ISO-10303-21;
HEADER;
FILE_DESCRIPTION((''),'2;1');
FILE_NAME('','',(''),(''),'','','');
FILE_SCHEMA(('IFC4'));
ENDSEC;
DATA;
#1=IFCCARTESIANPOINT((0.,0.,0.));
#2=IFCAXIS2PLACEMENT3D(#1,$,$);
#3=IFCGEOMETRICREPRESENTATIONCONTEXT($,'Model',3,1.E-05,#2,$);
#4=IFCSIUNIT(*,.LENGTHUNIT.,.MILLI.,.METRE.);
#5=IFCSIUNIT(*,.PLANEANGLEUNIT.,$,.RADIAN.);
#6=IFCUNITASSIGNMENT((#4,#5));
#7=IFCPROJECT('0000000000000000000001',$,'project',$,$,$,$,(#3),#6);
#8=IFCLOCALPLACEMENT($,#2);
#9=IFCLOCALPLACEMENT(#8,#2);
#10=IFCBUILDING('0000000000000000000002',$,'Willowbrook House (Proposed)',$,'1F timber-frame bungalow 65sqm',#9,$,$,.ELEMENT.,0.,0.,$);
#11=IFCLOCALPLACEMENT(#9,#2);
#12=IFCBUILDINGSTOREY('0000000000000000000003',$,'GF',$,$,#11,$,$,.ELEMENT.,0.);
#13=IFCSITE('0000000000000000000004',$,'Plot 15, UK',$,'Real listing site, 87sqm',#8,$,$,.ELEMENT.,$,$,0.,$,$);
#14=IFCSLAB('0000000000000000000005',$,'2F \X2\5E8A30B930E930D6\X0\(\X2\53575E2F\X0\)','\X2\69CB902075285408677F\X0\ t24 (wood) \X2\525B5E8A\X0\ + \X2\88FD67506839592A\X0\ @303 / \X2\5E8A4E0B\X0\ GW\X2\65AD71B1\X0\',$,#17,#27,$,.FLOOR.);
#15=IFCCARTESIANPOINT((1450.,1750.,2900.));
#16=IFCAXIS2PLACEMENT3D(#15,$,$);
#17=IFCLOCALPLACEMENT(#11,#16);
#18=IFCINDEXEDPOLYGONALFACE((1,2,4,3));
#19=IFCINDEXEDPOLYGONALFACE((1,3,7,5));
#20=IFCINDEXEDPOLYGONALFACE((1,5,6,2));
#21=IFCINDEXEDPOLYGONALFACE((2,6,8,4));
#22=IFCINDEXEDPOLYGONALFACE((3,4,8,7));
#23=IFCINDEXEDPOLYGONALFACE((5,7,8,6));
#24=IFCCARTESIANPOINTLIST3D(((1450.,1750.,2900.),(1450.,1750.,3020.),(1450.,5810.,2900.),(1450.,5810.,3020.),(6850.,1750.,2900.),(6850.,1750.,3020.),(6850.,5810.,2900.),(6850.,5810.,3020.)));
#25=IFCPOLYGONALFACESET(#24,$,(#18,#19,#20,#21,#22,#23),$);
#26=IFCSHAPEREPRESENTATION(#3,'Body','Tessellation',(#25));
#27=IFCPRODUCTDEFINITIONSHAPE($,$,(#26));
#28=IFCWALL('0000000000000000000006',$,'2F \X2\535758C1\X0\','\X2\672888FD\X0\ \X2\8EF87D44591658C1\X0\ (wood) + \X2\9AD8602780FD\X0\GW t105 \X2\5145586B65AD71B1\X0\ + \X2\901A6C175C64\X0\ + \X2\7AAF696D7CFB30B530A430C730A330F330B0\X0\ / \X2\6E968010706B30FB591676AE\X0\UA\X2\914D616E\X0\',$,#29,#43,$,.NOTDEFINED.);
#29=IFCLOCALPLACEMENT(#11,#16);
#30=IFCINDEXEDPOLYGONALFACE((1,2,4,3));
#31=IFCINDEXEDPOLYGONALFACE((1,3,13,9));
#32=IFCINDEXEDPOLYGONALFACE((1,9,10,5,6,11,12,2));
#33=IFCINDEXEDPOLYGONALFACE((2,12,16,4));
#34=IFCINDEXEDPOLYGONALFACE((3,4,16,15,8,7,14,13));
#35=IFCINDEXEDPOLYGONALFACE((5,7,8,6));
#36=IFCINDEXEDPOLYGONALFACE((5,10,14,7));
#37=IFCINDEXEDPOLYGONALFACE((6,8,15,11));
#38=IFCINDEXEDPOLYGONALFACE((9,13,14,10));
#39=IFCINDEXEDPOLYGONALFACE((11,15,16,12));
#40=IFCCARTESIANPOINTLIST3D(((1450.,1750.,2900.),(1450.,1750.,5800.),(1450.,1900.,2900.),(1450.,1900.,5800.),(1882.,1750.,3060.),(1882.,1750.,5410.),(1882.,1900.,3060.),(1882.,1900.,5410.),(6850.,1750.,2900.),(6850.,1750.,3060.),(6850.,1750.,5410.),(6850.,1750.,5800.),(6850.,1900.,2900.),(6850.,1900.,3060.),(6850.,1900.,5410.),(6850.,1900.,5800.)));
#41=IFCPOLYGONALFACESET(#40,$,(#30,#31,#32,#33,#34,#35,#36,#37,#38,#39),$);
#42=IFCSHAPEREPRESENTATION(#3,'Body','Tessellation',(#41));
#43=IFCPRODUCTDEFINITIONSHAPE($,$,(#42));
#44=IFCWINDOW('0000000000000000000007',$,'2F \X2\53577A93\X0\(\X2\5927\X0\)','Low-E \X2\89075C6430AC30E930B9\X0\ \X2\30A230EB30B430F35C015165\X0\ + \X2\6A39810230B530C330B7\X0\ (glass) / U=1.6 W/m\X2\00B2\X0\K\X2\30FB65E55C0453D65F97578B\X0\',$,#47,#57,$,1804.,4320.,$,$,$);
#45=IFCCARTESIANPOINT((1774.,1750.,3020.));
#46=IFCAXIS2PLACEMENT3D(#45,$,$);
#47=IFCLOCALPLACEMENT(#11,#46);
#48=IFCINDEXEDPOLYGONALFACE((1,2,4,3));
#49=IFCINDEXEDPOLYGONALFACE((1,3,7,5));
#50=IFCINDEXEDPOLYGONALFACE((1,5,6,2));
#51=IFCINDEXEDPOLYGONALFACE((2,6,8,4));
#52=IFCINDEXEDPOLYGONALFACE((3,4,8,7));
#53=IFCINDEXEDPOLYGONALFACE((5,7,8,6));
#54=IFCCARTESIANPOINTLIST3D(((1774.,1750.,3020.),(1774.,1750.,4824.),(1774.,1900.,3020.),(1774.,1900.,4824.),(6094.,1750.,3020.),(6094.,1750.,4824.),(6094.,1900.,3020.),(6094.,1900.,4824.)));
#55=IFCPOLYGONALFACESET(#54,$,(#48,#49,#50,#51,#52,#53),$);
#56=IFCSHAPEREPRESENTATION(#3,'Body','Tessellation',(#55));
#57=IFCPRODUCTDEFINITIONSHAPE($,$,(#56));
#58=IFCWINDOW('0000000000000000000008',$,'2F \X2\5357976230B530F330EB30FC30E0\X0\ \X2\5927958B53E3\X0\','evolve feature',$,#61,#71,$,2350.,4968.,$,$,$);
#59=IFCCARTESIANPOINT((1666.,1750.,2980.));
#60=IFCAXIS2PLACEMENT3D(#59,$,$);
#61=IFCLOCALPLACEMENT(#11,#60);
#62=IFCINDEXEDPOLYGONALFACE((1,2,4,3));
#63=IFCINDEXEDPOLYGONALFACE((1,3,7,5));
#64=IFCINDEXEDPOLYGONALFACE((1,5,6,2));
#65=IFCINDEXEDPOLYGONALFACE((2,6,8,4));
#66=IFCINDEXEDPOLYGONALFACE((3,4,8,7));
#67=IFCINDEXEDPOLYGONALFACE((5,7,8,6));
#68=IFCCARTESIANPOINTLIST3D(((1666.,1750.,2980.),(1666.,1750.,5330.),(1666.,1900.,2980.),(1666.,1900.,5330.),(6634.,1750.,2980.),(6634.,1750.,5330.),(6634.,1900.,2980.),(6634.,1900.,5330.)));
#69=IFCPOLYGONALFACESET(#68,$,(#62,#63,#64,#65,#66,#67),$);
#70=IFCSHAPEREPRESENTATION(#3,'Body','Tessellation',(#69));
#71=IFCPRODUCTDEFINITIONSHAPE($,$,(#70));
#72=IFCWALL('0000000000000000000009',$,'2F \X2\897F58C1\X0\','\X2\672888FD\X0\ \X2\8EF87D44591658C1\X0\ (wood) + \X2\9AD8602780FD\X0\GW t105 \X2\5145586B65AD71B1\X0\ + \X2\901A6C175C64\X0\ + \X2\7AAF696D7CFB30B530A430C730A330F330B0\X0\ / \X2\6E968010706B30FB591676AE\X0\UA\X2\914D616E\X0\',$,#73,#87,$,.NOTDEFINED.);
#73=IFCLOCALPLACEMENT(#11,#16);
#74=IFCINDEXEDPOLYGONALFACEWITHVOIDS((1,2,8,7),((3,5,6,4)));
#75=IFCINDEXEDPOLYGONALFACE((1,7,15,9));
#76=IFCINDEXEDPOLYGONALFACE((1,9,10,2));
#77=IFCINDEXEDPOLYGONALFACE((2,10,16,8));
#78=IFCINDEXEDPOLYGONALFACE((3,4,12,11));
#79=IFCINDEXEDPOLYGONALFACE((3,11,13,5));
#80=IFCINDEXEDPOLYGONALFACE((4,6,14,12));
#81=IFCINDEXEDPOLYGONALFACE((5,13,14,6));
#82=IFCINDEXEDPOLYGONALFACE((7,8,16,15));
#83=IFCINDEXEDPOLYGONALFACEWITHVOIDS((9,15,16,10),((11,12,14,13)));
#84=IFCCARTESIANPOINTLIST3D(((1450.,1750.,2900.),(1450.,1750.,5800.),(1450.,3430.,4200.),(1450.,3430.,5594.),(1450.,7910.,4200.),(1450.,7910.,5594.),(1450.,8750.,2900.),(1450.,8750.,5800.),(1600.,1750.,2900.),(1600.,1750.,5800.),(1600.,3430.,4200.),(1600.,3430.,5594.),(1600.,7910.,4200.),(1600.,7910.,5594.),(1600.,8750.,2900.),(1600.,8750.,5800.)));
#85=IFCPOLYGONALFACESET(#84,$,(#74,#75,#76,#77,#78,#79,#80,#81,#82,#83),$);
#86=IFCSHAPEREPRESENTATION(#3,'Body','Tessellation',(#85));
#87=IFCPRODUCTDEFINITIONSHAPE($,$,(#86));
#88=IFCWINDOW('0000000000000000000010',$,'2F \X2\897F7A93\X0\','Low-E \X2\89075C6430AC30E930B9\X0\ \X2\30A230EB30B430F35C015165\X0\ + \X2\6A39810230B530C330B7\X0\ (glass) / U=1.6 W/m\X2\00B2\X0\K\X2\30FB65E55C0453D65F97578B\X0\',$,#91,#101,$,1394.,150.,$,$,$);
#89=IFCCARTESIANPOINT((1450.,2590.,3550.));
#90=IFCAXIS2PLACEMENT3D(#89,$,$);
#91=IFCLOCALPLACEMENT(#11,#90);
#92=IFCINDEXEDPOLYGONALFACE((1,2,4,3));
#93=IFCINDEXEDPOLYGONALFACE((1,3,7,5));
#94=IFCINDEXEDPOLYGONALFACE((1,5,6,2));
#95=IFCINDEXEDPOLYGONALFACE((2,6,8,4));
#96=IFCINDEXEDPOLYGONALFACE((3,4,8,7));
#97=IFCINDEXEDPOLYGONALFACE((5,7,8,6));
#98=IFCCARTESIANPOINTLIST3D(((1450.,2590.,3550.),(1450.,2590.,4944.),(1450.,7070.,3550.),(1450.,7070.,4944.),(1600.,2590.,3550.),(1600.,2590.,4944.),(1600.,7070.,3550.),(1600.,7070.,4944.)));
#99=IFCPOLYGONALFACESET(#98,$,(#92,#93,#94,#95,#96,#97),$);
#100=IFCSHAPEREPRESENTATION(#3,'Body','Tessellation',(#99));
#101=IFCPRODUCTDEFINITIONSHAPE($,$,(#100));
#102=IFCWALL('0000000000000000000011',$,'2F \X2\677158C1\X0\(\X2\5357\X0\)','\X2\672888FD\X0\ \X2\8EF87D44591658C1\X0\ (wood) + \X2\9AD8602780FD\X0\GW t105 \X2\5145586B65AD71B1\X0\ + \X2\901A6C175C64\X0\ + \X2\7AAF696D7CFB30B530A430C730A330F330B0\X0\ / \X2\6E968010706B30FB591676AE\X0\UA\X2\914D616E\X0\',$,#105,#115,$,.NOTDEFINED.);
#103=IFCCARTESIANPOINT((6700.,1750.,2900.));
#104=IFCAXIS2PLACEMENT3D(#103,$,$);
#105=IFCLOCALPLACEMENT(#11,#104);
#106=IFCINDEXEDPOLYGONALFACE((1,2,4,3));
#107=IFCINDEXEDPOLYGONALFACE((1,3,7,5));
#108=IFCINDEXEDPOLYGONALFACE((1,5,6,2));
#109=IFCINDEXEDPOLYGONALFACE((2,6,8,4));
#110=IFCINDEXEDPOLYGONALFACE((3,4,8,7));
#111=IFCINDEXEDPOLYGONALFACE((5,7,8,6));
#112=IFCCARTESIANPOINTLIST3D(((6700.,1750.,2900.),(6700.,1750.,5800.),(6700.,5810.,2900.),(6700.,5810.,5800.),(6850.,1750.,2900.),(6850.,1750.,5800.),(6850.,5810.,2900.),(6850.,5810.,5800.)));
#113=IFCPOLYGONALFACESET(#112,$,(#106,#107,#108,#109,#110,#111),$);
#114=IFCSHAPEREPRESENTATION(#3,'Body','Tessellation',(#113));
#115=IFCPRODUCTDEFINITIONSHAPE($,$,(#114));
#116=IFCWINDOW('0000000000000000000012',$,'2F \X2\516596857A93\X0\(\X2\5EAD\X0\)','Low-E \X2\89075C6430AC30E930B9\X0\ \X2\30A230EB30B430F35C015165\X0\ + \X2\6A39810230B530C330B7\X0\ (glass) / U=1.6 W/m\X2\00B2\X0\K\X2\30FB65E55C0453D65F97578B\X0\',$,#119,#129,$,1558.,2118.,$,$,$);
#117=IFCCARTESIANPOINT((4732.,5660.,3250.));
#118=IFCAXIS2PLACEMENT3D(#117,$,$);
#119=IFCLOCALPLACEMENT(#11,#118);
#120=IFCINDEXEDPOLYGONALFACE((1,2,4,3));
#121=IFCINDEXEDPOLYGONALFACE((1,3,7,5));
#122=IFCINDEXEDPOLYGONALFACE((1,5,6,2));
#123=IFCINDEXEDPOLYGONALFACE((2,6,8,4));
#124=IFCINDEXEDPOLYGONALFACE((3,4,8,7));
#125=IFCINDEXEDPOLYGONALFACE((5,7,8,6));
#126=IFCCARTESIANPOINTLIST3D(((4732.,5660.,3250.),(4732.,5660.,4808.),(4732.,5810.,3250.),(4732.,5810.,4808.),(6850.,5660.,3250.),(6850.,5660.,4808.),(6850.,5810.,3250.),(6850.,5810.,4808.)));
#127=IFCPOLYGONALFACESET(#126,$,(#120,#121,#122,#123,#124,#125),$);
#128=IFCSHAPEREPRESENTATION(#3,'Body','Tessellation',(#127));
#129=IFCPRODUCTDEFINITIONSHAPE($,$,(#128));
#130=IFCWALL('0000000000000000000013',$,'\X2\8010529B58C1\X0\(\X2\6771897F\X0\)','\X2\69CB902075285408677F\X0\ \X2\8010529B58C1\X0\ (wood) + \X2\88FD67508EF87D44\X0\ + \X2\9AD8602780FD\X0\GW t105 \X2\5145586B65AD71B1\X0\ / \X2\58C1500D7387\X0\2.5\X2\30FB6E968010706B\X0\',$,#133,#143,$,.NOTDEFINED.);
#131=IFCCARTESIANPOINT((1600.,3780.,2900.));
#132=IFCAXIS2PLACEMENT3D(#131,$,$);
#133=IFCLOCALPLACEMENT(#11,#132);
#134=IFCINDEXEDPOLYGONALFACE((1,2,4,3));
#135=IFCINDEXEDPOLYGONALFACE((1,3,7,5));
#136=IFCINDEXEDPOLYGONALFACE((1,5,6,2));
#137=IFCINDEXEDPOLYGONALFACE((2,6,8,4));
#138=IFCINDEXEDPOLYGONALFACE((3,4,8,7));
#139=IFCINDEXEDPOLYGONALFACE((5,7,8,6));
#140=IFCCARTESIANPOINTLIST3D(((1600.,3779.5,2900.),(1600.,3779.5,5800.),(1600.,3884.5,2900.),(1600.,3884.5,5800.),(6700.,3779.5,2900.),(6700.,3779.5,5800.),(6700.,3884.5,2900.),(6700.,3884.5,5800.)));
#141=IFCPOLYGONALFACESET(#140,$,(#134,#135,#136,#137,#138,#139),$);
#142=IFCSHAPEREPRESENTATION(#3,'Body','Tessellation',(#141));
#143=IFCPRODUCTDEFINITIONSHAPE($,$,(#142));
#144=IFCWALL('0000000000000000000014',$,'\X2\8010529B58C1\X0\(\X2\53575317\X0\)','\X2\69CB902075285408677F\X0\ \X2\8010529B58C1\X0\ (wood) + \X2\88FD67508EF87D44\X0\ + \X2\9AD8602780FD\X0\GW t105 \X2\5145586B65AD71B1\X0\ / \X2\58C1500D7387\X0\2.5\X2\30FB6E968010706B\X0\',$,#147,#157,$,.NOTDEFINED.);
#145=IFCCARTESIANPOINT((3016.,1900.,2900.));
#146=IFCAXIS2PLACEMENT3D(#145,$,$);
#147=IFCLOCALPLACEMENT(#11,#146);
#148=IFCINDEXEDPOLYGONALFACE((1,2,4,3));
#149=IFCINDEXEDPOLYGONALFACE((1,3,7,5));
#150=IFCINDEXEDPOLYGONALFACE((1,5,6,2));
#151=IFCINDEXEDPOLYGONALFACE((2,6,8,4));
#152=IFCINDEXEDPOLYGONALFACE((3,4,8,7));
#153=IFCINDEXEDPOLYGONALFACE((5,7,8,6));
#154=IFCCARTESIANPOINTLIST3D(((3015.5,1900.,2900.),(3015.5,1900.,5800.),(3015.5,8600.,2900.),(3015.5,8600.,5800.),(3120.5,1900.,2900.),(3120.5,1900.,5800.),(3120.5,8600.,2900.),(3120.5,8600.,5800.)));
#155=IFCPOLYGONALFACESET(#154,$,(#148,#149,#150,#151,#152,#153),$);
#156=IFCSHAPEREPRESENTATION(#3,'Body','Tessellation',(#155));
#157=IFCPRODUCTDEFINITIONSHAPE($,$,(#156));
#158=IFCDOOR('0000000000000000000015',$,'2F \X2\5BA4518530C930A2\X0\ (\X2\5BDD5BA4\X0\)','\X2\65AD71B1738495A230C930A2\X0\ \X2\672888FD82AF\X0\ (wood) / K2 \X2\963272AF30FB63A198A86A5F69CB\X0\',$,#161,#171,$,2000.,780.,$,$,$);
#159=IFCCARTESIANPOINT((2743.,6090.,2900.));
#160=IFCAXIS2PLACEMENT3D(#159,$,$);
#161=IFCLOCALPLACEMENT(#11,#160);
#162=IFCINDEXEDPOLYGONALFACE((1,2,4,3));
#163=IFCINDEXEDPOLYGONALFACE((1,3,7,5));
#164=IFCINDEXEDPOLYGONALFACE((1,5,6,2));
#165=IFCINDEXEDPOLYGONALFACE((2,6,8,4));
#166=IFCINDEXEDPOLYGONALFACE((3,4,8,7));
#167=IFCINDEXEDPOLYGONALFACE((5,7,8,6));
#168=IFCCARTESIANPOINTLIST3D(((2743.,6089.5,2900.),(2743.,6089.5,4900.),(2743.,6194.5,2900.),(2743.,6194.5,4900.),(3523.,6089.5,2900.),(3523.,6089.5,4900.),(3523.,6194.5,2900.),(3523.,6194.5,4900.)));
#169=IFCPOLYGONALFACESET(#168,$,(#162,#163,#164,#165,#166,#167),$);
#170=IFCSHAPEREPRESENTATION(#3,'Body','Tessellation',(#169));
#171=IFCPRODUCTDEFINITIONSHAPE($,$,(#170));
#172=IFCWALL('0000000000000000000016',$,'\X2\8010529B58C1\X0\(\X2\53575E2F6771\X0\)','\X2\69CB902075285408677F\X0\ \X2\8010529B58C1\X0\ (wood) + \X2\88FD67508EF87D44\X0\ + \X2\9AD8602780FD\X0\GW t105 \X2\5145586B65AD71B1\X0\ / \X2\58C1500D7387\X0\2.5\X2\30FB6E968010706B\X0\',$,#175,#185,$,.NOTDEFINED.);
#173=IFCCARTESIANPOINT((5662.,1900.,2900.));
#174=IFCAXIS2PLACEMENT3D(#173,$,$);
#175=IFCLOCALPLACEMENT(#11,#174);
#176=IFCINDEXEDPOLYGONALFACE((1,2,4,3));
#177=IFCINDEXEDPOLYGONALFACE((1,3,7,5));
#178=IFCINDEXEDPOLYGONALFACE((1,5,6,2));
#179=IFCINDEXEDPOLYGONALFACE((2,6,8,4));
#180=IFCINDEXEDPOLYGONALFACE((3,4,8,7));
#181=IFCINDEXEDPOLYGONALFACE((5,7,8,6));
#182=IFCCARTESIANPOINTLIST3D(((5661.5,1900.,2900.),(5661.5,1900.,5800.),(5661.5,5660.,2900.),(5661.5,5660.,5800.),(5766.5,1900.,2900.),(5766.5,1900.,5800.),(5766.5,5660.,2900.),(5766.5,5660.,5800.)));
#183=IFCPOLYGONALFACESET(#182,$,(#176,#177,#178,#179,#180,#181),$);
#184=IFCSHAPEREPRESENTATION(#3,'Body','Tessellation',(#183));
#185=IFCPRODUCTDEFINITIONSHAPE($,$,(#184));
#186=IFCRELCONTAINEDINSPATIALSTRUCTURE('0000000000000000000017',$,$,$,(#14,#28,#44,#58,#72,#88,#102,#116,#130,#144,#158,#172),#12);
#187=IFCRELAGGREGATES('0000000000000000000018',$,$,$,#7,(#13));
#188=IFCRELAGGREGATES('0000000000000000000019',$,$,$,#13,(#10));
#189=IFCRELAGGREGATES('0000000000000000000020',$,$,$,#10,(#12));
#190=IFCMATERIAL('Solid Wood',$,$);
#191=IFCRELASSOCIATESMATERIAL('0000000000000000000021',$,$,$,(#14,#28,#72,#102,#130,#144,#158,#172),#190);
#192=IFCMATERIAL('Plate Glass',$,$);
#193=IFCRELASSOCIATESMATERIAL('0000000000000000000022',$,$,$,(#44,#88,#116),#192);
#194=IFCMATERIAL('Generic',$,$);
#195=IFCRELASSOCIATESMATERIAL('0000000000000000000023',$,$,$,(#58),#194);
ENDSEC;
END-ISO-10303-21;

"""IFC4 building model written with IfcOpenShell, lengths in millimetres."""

from ifc_helpers import new_model, si_unit, frame, frame_2d, origin, place, context, project, spatial, rectangle, extrude, material, element, fill, save


model = new_model("IFC4")

# Units and contexts
model_context = context("Model", 3, precision=1e-05, world=origin())
ifc_project = project(units=[si_unit("LENGTHUNIT", "METRE", prefix="MILLI"), si_unit("PLANEANGLEUNIT", "RADIAN")], contexts=[model_context])

# Site, building, storey
site_placement = place(None, origin())
site = spatial("IfcSite", under=ifc_project, at=site_placement, Name="Plot 15, UK", ObjectType="Real listing site, 87sqm", CompositionType="ELEMENT", RefElevation=0.0)
building_placement = place(site_placement, origin())
building = spatial("IfcBuilding", under=site, at=building_placement, Name="Willowbrook House (Proposed)", ObjectType="1F timber-frame bungalow 65sqm", CompositionType="ELEMENT", ElevationOfRefHeight=0.0, ElevationOfTerrain=0.0)
storey_placement = place(building_placement, origin())
storey = spatial("IfcBuildingStorey", under=building, at=storey_placement, Name="GF", CompositionType="ELEMENT", Elevation=0.0)

# Slab
ifc_material_1 = material(Name="Solid Wood")
slab_placement = place(storey_placement, frame((1450.0, 1750.0, 2900.0)))
element("IfcSlab", 1, at=slab_placement, inside=storey, material=ifc_material_1, Name="2F 床スラブ(南帯)", Description="構造用合板 t24 (wood) 剛床 + 製材根太 @303 / 床下 GW断熱", PredefinedType="FLOOR", context=model_context, shape_type="SweptSolid", body=[
    extrude(rectangle(XDim=5400.0, YDim=4060.0, at=frame_2d((2700.0, 2030.0))), frame((1450.0, 1750.0, 2900.0)), (0.0, 0.0, 1.0), 120.0),
])

# Wall, openings, windows
wall_1_placement = place(storey_placement, frame((1450.0, 1750.0, 2900.0)))
wall_1 = element("IfcWall", 2, at=wall_1_placement, inside=storey, material=ifc_material_1, Name="2F 南壁", Description="木製 軸組外壁 (wood) + 高性能GW t105 充填断熱 + 通気層 + 窯業系サイディング / 準耐火・外皮UA配慮", PredefinedType="NOTDEFINED", context=model_context, shape_type="SweptSolid", body=[
    extrude(rectangle(XDim=5400.0, YDim=150.0, at=frame_2d((2700.0, 75.0))), frame((1450.0, 1750.0, 2900.0)), (0.0, 0.0, 1.0), 2900.0),
])
opening_1_placement = place(storey_placement, frame((1774.0, 1750.0, 3020.0)))
opening_1 = element("IfcOpeningElement", 3, at=opening_1_placement, cuts=wall_1, PredefinedType="NOTDEFINED", context=model_context, shape_type="SweptSolid", body=[
    extrude(rectangle(XDim=4320.0, YDim=150.0, at=frame_2d((2160.0, 75.0))), frame((1774.0, 1750.0, 3020.0)), (0.0, 0.0, 1.0), 1804.0),
])
opening_2_placement = place(storey_placement, frame((1666.0, 1750.0, 2980.0)))
opening_2 = element("IfcOpeningElement", 4, at=opening_2_placement, cuts=wall_1, PredefinedType="NOTDEFINED", context=model_context, shape_type="SweptSolid", body=[
    extrude(rectangle(XDim=4968.0, YDim=150.0, at=frame_2d((2484.0, 75.0))), frame((1666.0, 1750.0, 2980.0)), (0.0, 0.0, 1.0), 2350.0),
])
ifc_material_2 = material(Name="Plate Glass")
window_1_placement = place(storey_placement, frame((1774.0, 1750.0, 3020.0)))
window_1 = element("IfcWindow", 5, at=window_1_placement, inside=storey, material=ifc_material_2, Name="2F 南窓(大)", Description="Low-E 複層ガラス アルゴン封入 + 樹脂サッシ (glass) / U=1.6 W/m²K・日射取得型", OverallHeight=1804.0, OverallWidth=4320.0, context=model_context, shape_type="SweptSolid", body=[
    extrude(rectangle(XDim=4320.0, YDim=150.0, at=frame_2d((2160.0, 75.0))), frame((1774.0, 1750.0, 3020.0)), (0.0, 0.0, 1.0), 1804.0),
])
fill(opening_1, window_1)
ifc_material_3 = material(Name="Generic")
window_2_placement = place(storey_placement, frame((1666.0, 1750.0, 2980.0)))
window_2 = element("IfcWindow", 6, at=window_2_placement, inside=storey, material=ifc_material_3, Name="2F 南面サンルーム 大開口", Description="evolve feature", OverallHeight=2350.0, OverallWidth=4968.0, context=model_context, shape_type="SweptSolid", body=[
    extrude(rectangle(XDim=4968.0, YDim=150.0, at=frame_2d((2484.0, 75.0))), frame((1666.0, 1750.0, 2980.0)), (0.0, 0.0, 1.0), 2350.0),
])
fill(opening_2, window_2)

# Walls, openings, windows
wall_2_placement = place(storey_placement, frame((1450.0, 1750.0, 2900.0)))
wall_2 = element("IfcWall", 7, at=wall_2_placement, inside=storey, material=ifc_material_1, Name="2F 西壁", Description="木製 軸組外壁 (wood) + 高性能GW t105 充填断熱 + 通気層 + 窯業系サイディング / 準耐火・外皮UA配慮", PredefinedType="NOTDEFINED", context=model_context, shape_type="SweptSolid", body=[
    extrude(rectangle(XDim=150.0, YDim=7000.0, at=frame_2d((75.0, 3500.0))), frame((1450.0, 1750.0, 2900.0)), (0.0, 0.0, 1.0), 2900.0),
])
opening_3_placement = place(storey_placement, frame((1450.0, 2590.0, 3550.0)))
opening_3 = element("IfcOpeningElement", 8, at=opening_3_placement, cuts=wall_2, PredefinedType="NOTDEFINED", context=model_context, shape_type="SweptSolid", body=[
    extrude(rectangle(XDim=150.0, YDim=4480.0, at=frame_2d((75.0, 2240.0))), frame((1450.0, 2590.0, 3550.0)), (0.0, 0.0, 1.0), 1394.0),
])
window_3_placement = place(storey_placement, frame((1450.0, 2590.0, 3550.0)))
window_3 = element("IfcWindow", 9, at=window_3_placement, inside=storey, material=ifc_material_2, Name="2F 西窓", Description="Low-E 複層ガラス アルゴン封入 + 樹脂サッシ (glass) / U=1.6 W/m²K・日射取得型", OverallHeight=1394.0, OverallWidth=150.0, context=model_context, shape_type="SweptSolid", body=[
    extrude(rectangle(XDim=150.0, YDim=4480.0, at=frame_2d((75.0, 2240.0))), frame((1450.0, 2590.0, 3550.0)), (0.0, 0.0, 1.0), 1394.0),
])
fill(opening_3, window_3)
wall_3_placement = place(storey_placement, frame((6700.0, 1750.0, 2900.0)))
wall_3 = element("IfcWall", 10, at=wall_3_placement, inside=storey, material=ifc_material_1, Name="2F 東壁(南)", Description="木製 軸組外壁 (wood) + 高性能GW t105 充填断熱 + 通気層 + 窯業系サイディング / 準耐火・外皮UA配慮", PredefinedType="NOTDEFINED", context=model_context, shape_type="SweptSolid", body=[
    extrude(rectangle(XDim=150.0, YDim=4060.0, at=frame_2d((75.0, 2030.0))), frame((6700.0, 1750.0, 2900.0)), (0.0, 0.0, 1.0), 2900.0),
])
opening_4_placement = place(storey_placement, frame((4732.0, 5660.0, 3250.0)))
opening_4 = element("IfcOpeningElement", 11, at=opening_4_placement, cuts=wall_3, PredefinedType="NOTDEFINED", context=model_context, shape_type="SweptSolid", body=[
    extrude(rectangle(XDim=2118.0, YDim=150.0, at=frame_2d((1059.0, 75.0))), frame((4732.0, 5660.0, 3250.0)), (0.0, 0.0, 1.0), 1558.0),
])
window_4_placement = place(storey_placement, frame((4732.0, 5660.0, 3250.0)))
window_4 = element("IfcWindow", 12, at=window_4_placement, inside=storey, material=ifc_material_2, Name="2F 入隅窓(庭)", Description="Low-E 複層ガラス アルゴン封入 + 樹脂サッシ (glass) / U=1.6 W/m²K・日射取得型", OverallHeight=1558.0, OverallWidth=2118.0, context=model_context, shape_type="SweptSolid", body=[
    extrude(rectangle(XDim=2118.0, YDim=150.0, at=frame_2d((1059.0, 75.0))), frame((4732.0, 5660.0, 3250.0)), (0.0, 0.0, 1.0), 1558.0),
])
fill(opening_4, window_4)

# Wall
wall_4_placement = place(storey_placement, frame((1600.0, 3780.0, 2900.0)))
element("IfcWall", 13, at=wall_4_placement, inside=storey, material=ifc_material_1, Name="耐力壁(東西)", Description="構造用合板 耐力壁 (wood) + 製材軸組 + 高性能GW t105 充填断熱 / 壁倍率2.5・準耐火", PredefinedType="NOTDEFINED", context=model_context, shape_type="SweptSolid", body=[
    extrude(rectangle(XDim=5100.0, YDim=105.0, at=frame_2d((2550.0, 52.0))), frame((1600.0, 3780.0, 2900.0)), (0.0, 0.0, 1.0), 2900.0),
])

# Wall, opening, door
wall_5_placement = place(storey_placement, frame((3016.0, 1900.0, 2900.0)))
wall_5 = element("IfcWall", 14, at=wall_5_placement, inside=storey, material=ifc_material_1, Name="耐力壁(南北)", Description="構造用合板 耐力壁 (wood) + 製材軸組 + 高性能GW t105 充填断熱 / 壁倍率2.5・準耐火", PredefinedType="NOTDEFINED", context=model_context, shape_type="SweptSolid", body=[
    extrude(rectangle(XDim=105.0, YDim=6700.0, at=frame_2d((52.0, 3350.0))), frame((3016.0, 1900.0, 2900.0)), (0.0, 0.0, 1.0), 2900.0),
])
opening_5_placement = place(storey_placement, frame((2743.0, 6090.0, 2900.0)))
opening_5 = element("IfcOpeningElement", 15, at=opening_5_placement, cuts=wall_5, PredefinedType="NOTDEFINED", context=model_context, shape_type="SweptSolid", body=[
    extrude(rectangle(XDim=780.0, YDim=105.0, at=frame_2d((390.0, 52.0))), frame((2743.0, 6090.0, 2900.0)), (0.0, 0.0, 1.0), 2000.0),
])
door_placement = place(storey_placement, frame((2743.0, 6090.0, 2900.0)))
door = element("IfcDoor", 16, at=door_placement, inside=storey, material=ifc_material_1, Name="2F 室内ドア (寝室)", Description="断熱玄関ドア 木製芯 (wood) / K2 防犯・採風機構", OverallHeight=2000.0, OverallWidth=780.0, context=model_context, shape_type="SweptSolid", body=[
    extrude(rectangle(XDim=780.0, YDim=105.0, at=frame_2d((390.0, 52.0))), frame((2743.0, 6090.0, 2900.0)), (0.0, 0.0, 1.0), 2000.0),
])
fill(opening_5, door)

# Wall
wall_6_placement = place(storey_placement, frame((5662.0, 1900.0, 2900.0)))
element("IfcWall", 17, at=wall_6_placement, inside=storey, material=ifc_material_1, Name="耐力壁(南帯東)", Description="構造用合板 耐力壁 (wood) + 製材軸組 + 高性能GW t105 充填断熱 / 壁倍率2.5・準耐火", PredefinedType="NOTDEFINED", context=model_context, shape_type="SweptSolid", body=[
    extrude(rectangle(XDim=105.0, YDim=3760.0, at=frame_2d((52.0, 1880.0))), frame((5662.0, 1900.0, 2900.0)), (0.0, 0.0, 1.0), 2900.0),
])

save(model, "model.ifc")
